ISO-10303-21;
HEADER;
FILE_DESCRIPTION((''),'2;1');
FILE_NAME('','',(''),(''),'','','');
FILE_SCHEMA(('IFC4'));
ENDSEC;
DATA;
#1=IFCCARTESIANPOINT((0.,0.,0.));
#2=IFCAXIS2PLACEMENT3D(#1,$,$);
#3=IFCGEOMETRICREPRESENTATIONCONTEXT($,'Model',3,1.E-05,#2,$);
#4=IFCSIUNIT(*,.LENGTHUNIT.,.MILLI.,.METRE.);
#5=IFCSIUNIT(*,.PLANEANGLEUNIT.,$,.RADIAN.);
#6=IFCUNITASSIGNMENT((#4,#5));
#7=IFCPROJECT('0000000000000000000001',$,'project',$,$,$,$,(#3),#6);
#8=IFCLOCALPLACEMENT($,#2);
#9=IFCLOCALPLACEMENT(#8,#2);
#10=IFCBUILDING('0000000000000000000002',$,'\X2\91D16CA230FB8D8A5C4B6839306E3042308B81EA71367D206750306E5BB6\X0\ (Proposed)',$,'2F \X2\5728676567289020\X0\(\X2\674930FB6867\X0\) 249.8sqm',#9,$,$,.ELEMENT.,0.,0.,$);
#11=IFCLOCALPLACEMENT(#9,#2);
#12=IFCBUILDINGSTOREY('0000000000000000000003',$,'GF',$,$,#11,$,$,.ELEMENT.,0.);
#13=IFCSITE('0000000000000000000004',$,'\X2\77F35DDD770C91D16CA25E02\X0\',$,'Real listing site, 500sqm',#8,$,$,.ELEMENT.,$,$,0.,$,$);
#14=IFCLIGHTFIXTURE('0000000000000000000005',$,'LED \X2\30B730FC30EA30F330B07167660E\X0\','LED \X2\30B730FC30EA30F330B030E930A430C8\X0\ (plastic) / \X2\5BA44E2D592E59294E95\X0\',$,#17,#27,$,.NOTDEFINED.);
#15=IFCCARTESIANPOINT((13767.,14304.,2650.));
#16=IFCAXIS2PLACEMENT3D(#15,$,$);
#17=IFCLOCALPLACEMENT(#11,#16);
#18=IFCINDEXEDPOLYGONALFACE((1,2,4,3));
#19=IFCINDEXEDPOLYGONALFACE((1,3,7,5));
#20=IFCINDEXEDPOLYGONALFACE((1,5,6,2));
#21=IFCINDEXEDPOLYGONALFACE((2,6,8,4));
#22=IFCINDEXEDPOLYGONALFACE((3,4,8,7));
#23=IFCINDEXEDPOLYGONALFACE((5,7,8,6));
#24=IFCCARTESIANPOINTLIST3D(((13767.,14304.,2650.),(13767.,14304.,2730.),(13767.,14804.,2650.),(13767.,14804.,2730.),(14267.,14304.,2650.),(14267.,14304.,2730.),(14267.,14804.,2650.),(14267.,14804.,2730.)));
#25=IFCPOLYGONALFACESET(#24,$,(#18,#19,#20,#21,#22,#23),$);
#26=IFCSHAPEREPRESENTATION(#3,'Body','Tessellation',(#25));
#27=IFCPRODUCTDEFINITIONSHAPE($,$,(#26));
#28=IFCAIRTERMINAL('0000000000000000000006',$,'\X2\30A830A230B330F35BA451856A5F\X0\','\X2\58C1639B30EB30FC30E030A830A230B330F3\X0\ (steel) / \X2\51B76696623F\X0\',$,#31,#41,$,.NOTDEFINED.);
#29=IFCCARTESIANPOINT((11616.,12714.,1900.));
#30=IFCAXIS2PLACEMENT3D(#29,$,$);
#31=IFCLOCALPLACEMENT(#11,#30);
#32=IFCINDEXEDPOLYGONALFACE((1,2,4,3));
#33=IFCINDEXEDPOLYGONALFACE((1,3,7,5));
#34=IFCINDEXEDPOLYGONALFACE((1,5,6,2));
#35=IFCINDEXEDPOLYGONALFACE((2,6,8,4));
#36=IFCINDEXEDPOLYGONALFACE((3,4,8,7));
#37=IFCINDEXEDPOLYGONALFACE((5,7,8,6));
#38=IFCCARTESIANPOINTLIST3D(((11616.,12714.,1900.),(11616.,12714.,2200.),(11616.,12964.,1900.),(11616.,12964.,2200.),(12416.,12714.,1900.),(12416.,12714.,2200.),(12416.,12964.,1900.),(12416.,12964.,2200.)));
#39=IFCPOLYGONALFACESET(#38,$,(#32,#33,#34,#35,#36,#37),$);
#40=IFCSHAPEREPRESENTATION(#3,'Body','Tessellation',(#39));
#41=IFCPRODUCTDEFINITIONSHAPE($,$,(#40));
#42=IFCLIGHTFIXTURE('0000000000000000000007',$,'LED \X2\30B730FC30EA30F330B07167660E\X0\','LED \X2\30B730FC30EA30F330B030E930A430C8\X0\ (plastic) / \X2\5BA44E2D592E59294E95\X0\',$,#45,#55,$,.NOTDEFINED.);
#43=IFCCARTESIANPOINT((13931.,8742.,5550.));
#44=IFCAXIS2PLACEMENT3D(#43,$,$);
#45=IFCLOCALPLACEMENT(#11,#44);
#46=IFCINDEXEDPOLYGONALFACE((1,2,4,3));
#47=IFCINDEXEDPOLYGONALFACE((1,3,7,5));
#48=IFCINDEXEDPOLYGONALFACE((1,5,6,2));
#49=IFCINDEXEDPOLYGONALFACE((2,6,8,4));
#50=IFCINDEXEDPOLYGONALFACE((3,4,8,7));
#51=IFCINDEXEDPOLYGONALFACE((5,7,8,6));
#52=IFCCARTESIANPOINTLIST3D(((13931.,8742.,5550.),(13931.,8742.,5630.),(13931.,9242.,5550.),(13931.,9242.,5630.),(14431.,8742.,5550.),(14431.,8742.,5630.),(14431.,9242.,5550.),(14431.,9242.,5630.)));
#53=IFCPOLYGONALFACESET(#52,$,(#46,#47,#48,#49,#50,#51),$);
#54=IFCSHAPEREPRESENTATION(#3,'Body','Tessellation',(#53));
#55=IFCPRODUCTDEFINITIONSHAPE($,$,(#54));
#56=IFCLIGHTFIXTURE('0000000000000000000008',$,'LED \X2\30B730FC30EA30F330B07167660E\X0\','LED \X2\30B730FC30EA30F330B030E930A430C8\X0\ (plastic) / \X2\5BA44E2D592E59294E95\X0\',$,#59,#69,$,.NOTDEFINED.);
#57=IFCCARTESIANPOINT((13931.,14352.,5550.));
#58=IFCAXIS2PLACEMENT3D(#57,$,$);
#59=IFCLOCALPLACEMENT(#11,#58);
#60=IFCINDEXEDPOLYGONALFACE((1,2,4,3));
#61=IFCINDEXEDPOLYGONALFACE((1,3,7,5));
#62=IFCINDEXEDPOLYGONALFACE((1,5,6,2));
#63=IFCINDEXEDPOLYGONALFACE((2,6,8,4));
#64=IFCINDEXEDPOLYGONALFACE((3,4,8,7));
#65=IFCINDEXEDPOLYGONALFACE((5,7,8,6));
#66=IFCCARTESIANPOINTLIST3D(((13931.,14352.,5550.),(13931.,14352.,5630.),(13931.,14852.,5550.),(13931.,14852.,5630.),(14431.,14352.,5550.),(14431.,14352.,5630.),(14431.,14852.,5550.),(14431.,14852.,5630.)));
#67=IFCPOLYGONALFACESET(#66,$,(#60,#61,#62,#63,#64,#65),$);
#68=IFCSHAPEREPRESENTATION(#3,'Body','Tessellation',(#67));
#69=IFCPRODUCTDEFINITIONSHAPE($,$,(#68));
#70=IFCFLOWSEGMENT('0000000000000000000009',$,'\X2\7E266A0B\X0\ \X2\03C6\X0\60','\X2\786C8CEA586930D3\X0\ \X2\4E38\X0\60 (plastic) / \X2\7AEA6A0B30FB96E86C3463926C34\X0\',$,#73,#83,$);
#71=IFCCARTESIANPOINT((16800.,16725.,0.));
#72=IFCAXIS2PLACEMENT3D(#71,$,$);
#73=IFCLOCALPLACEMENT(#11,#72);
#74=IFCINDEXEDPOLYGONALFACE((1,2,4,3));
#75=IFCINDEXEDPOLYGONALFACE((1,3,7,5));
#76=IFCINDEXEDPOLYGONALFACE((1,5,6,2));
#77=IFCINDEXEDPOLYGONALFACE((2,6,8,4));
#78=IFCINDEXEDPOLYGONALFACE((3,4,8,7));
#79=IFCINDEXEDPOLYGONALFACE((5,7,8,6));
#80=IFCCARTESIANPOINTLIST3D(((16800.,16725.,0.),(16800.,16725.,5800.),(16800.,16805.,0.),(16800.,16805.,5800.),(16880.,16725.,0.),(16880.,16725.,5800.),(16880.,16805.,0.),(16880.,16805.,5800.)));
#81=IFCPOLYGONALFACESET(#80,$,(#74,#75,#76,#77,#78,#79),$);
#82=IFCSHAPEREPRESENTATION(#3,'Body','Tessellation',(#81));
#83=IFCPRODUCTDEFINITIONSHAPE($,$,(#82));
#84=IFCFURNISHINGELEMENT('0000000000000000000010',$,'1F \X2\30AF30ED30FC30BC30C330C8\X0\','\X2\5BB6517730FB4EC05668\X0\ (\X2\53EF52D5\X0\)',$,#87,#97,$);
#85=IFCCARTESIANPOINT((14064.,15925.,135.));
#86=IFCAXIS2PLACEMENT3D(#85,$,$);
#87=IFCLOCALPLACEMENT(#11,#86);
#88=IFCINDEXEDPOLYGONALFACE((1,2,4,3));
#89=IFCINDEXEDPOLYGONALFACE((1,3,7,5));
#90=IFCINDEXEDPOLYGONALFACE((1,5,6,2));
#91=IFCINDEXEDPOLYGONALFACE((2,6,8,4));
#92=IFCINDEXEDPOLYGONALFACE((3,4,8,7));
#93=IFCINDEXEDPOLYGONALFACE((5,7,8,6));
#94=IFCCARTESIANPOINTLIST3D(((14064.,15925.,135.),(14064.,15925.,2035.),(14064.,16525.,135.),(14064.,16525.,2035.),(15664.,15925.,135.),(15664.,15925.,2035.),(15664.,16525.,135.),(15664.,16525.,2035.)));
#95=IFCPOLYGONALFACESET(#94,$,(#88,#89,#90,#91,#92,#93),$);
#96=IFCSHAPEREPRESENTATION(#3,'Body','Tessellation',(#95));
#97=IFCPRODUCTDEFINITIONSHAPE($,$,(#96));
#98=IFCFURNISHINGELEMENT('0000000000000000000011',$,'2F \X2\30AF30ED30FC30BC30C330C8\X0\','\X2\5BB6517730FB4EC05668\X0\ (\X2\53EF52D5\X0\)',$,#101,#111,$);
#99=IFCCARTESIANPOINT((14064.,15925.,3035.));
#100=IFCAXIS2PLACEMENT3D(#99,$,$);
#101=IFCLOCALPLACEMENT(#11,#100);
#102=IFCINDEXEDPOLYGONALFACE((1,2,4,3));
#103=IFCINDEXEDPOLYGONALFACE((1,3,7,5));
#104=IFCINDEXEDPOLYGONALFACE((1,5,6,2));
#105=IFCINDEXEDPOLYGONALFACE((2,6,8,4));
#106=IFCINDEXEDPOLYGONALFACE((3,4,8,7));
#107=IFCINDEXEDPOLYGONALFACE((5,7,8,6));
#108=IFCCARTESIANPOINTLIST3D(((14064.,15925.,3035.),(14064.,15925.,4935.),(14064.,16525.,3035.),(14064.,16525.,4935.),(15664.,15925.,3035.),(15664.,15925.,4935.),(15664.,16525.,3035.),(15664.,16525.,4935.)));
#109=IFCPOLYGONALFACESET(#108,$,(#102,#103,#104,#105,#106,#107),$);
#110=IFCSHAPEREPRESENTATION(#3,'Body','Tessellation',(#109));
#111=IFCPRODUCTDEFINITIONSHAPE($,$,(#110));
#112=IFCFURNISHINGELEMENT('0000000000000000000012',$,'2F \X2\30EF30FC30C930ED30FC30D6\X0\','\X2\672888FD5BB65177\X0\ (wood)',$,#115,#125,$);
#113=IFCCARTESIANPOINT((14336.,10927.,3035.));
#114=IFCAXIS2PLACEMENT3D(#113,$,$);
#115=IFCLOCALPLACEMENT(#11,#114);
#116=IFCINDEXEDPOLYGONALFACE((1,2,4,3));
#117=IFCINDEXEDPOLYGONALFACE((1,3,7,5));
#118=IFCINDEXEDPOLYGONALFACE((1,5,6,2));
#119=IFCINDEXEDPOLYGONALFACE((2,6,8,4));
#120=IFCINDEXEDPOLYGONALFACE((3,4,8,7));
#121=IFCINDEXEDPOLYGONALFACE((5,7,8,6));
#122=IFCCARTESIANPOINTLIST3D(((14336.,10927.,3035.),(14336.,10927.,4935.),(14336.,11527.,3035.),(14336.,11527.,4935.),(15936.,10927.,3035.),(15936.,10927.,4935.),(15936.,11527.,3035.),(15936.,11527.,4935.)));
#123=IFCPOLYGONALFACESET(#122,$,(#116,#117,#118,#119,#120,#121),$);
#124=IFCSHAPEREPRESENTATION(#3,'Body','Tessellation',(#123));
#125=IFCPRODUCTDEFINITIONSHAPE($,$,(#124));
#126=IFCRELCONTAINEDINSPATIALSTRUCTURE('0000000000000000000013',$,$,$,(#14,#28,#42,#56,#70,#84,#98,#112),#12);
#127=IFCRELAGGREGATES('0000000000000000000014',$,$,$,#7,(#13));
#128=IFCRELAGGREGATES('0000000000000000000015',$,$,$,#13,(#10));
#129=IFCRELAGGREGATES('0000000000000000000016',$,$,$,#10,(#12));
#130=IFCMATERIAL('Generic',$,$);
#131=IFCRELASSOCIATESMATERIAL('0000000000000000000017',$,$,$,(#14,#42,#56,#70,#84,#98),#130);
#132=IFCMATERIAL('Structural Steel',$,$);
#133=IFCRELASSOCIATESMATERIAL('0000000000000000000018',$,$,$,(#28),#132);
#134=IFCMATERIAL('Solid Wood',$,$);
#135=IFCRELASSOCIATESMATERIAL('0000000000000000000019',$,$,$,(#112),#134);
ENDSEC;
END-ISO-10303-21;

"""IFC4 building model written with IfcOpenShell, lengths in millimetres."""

from ifc_helpers import new_model, si_unit, frame, frame_2d, origin, place, context, project, spatial, rectangle, extrude, material, element, save


model = new_model("IFC4")

# Units and contexts
model_context = context("Model", 3, precision=1e-05, world=origin())
ifc_project = project(units=[si_unit("LENGTHUNIT", "METRE", prefix="MILLI"), si_unit("PLANEANGLEUNIT", "RADIAN")], contexts=[model_context])

# Site, building, storey
site_placement = place(None, origin())
site = spatial("IfcSite", under=ifc_project, at=site_placement, Name="石川県金沢市", ObjectType="Real listing site, 500sqm", CompositionType="ELEMENT", RefElevation=0.0)
building_placement = place(site_placement, origin())
building = spatial("IfcBuilding", under=site, at=building_placement, Name="金沢・越屋根のある自然素材の家 (Proposed)", ObjectType="2F 在来木造(杉・桧) 249.8sqm", CompositionType="ELEMENT", ElevationOfRefHeight=0.0, ElevationOfTerrain=0.0)
storey_placement = place(building_placement, origin())
storey = spatial("IfcBuildingStorey", under=building, at=storey_placement, Name="GF", CompositionType="ELEMENT", Elevation=0.0)

# Shared definitions
ifc_material_1 = material(Name="Solid Wood")

# Shared definitions
ifc_material_2 = material(Name="Structural Steel")

# Shared definitions
ifc_material_3 = material(Name="Generic")

# Light fixture
light_fixture_1_placement = place(storey_placement, frame((13767.0, 14304.0, 2650.0)))
element("IfcLightFixture", 1, at=light_fixture_1_placement, inside=storey, material=ifc_material_3, Name="LED シーリング照明", Description="LED シーリングライト (plastic) / 室中央天井", PredefinedType="NOTDEFINED", context=model_context, shape_type="SweptSolid", body=[
    extrude(rectangle(XDim=500.0, YDim=500.0, at=frame_2d((250.0, 250.0))), frame((13767.0, 14304.0, 2650.0)), (0.0, 0.0, 1.0), 80.0),
])

# Air terminal
air_terminal_placement = place(storey_placement, frame((11616.0, 12714.0, 1900.0)))
element("IfcAirTerminal", 2, at=air_terminal_placement, inside=storey, material=ifc_material_2, Name="エアコン室内機", Description="壁掛ルームエアコン (steel) / 冷暖房", PredefinedType="NOTDEFINED", context=model_context, shape_type="SweptSolid", body=[
    extrude(rectangle(XDim=800.0, YDim=250.0, at=frame_2d((400.0, 125.0))), frame((11616.0, 12714.0, 1900.0)), (0.0, 0.0, 1.0), 300.0),
])

# Light fixtures
light_fixture_2_placement = place(storey_placement, frame((13931.0, 8742.0, 5550.0)))
element("IfcLightFixture", 3, at=light_fixture_2_placement, inside=storey, material=ifc_material_3, Name="LED シーリング照明", Description="LED シーリングライト (plastic) / 室中央天井", PredefinedType="NOTDEFINED", context=model_context, shape_type="SweptSolid", body=[
    extrude(rectangle(XDim=500.0, YDim=500.0, at=frame_2d((250.0, 250.0))), frame((13931.0, 8742.0, 5550.0)), (0.0, 0.0, 1.0), 80.0),
])
light_fixture_3_placement = place(storey_placement, frame((13931.0, 14352.0, 5550.0)))
element("IfcLightFixture", 4, at=light_fixture_3_placement, inside=storey, material=ifc_material_3, Name="LED シーリング照明", Description="LED シーリングライト (plastic) / 室中央天井", PredefinedType="NOTDEFINED", context=model_context, shape_type="SweptSolid", body=[
    extrude(rectangle(XDim=500.0, YDim=500.0, at=frame_2d((250.0, 250.0))), frame((13931.0, 14352.0, 5550.0)), (0.0, 0.0, 1.0), 80.0),
])

# Flow segment
flow_segment_placement = place(storey_placement, frame((16800.0, 16725.0, 0.0)))
element("IfcFlowSegment", 5, at=flow_segment_placement, inside=storey, material=ifc_material_3, Name="縦樋 φ60", Description="硬質塩ビ 丸60 (plastic) / 竪樋・雨水排水", context=model_context, shape_type="SweptSolid", body=[
    extrude(rectangle(XDim=80.0, YDim=80.0, at=frame_2d((40.0, 40.0))), frame((16800.0, 16725.0, 0.0)), (0.0, 0.0, 1.0), 5800.0),
])

# Furnishing elements
furnishing_1_placement = place(storey_placement, frame((14064.0, 15925.0, 135.0)))
element("IfcFurnishingElement", 6, at=furnishing_1_placement, inside=storey, material=ifc_material_3, Name="1F クローゼット", Description="家具・什器 (可動)", context=model_context, shape_type="SweptSolid", body=[
    extrude(rectangle(XDim=1600.0, YDim=600.0, at=frame_2d((800.0, 300.0))), frame((14064.0, 15925.0, 135.0)), (0.0, 0.0, 1.0), 1900.0),
])
furnishing_2_placement = place(storey_placement, frame((14064.0, 15925.0, 3035.0)))
element("IfcFurnishingElement", 7, at=furnishing_2_placement, inside=storey, material=ifc_material_3, Name="2F クローゼット", Description="家具・什器 (可動)", context=model_context, shape_type="SweptSolid", body=[
    extrude(rectangle(XDim=1600.0, YDim=600.0, at=frame_2d((800.0, 300.0))), frame((14064.0, 15925.0, 3035.0)), (0.0, 0.0, 1.0), 1900.0),
])
furnishing_3_placement = place(storey_placement, frame((14336.0, 10927.0, 3035.0)))
element("IfcFurnishingElement", 8, at=furnishing_3_placement, inside=storey, material=ifc_material_1, Name="2F ワードローブ", Description="木製家具 (wood)", context=model_context, shape_type="SweptSolid", body=[
    extrude(rectangle(XDim=1600.0, YDim=600.0, at=frame_2d((800.0, 300.0))), frame((14336.0, 10927.0, 3035.0)), (0.0, 0.0, 1.0), 1900.0),
])

save(model, "model.ifc")
